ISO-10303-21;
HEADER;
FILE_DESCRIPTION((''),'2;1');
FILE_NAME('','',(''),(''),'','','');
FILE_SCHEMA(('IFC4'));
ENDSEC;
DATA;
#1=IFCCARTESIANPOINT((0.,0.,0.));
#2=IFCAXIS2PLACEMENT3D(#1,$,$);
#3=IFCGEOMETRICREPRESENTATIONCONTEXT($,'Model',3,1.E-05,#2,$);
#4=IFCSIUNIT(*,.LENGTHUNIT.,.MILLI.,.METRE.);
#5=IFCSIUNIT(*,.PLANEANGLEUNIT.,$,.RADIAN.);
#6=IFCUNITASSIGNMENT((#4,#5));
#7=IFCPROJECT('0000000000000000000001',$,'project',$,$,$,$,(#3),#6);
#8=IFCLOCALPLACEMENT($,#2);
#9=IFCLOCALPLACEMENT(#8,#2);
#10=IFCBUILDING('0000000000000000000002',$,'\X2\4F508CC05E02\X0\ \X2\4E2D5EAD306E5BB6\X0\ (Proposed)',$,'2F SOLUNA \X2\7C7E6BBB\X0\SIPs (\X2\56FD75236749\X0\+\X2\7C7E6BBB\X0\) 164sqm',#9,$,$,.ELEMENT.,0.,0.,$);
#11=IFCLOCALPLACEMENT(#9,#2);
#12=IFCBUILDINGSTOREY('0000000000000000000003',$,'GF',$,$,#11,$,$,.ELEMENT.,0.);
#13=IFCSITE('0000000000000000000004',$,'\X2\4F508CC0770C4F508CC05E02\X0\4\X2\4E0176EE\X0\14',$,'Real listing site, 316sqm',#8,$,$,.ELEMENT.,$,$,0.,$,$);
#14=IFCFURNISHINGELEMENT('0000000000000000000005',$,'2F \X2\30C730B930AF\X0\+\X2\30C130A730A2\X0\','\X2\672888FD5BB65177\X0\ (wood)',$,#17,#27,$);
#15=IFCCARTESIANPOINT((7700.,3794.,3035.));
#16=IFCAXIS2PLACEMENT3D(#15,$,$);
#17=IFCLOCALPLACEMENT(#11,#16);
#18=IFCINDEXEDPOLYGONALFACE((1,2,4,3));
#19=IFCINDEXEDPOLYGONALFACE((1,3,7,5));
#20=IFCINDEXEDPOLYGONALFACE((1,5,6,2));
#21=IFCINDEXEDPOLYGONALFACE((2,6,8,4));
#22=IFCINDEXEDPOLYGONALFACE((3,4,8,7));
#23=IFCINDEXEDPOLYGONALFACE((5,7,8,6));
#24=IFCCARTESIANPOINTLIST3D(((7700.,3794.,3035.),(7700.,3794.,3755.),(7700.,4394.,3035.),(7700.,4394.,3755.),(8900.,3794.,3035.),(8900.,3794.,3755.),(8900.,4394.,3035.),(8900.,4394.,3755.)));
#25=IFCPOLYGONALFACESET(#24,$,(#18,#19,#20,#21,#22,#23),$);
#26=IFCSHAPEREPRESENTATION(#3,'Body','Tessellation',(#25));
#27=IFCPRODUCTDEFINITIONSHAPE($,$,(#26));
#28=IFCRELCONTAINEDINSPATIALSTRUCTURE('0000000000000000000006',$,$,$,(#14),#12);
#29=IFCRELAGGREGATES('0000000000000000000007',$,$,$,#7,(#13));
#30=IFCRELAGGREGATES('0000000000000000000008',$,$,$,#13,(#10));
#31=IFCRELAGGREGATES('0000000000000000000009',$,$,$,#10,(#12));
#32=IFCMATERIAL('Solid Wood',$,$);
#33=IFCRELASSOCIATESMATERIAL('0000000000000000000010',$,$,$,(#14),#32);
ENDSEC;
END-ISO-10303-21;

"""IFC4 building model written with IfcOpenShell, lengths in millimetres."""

from ifc_helpers import new_model, si_unit, frame, frame_2d, origin, place, context, project, spatial, rectangle, extrude, material, element, save


model = new_model("IFC4")

# Units and contexts
model_context = context("Model", 3, precision=1e-05, world=origin())
ifc_project = project(units=[si_unit("LENGTHUNIT", "METRE", prefix="MILLI"), si_unit("PLANEANGLEUNIT", "RADIAN")], contexts=[model_context])

# Site, building, storey
site_placement = place(None, origin())
site = spatial("IfcSite", under=ifc_project, at=site_placement, Name="佐賀県佐賀市4丁目14", ObjectType="Real listing site, 316sqm", CompositionType="ELEMENT", RefElevation=0.0)
building_placement = place(site_placement, origin())
building = spatial("IfcBuilding", under=site, at=building_placement, Name="佐賀市 中庭の家 (Proposed)", ObjectType="2F SOLUNA 籾殻SIPs (国産杉+籾殻) 164sqm", CompositionType="ELEMENT", ElevationOfRefHeight=0.0, ElevationOfTerrain=0.0)
storey_placement = place(building_placement, origin())
storey = spatial("IfcBuildingStorey", under=building, at=storey_placement, Name="GF", CompositionType="ELEMENT", Elevation=0.0)

# Shared definitions
ifc_material_1 = material(Name="Solid Wood")

# Furnishing element
furnishing_1_placement = place(storey_placement, frame((7700.0, 3794.0, 3035.0)))
element("IfcFurnishingElement", 1, at=furnishing_1_placement, inside=storey, material=ifc_material_1, Name="2F デスク+チェア", Description="木製家具 (wood)", context=model_context, shape_type="SweptSolid", body=[
    extrude(rectangle(XDim=1200.0, YDim=600.0, at=frame_2d((600.0, 300.0))), frame((7700.0, 3794.0, 3035.0)), (0.0, 0.0, 1.0), 720.0),
])

save(model, "model.ifc")
